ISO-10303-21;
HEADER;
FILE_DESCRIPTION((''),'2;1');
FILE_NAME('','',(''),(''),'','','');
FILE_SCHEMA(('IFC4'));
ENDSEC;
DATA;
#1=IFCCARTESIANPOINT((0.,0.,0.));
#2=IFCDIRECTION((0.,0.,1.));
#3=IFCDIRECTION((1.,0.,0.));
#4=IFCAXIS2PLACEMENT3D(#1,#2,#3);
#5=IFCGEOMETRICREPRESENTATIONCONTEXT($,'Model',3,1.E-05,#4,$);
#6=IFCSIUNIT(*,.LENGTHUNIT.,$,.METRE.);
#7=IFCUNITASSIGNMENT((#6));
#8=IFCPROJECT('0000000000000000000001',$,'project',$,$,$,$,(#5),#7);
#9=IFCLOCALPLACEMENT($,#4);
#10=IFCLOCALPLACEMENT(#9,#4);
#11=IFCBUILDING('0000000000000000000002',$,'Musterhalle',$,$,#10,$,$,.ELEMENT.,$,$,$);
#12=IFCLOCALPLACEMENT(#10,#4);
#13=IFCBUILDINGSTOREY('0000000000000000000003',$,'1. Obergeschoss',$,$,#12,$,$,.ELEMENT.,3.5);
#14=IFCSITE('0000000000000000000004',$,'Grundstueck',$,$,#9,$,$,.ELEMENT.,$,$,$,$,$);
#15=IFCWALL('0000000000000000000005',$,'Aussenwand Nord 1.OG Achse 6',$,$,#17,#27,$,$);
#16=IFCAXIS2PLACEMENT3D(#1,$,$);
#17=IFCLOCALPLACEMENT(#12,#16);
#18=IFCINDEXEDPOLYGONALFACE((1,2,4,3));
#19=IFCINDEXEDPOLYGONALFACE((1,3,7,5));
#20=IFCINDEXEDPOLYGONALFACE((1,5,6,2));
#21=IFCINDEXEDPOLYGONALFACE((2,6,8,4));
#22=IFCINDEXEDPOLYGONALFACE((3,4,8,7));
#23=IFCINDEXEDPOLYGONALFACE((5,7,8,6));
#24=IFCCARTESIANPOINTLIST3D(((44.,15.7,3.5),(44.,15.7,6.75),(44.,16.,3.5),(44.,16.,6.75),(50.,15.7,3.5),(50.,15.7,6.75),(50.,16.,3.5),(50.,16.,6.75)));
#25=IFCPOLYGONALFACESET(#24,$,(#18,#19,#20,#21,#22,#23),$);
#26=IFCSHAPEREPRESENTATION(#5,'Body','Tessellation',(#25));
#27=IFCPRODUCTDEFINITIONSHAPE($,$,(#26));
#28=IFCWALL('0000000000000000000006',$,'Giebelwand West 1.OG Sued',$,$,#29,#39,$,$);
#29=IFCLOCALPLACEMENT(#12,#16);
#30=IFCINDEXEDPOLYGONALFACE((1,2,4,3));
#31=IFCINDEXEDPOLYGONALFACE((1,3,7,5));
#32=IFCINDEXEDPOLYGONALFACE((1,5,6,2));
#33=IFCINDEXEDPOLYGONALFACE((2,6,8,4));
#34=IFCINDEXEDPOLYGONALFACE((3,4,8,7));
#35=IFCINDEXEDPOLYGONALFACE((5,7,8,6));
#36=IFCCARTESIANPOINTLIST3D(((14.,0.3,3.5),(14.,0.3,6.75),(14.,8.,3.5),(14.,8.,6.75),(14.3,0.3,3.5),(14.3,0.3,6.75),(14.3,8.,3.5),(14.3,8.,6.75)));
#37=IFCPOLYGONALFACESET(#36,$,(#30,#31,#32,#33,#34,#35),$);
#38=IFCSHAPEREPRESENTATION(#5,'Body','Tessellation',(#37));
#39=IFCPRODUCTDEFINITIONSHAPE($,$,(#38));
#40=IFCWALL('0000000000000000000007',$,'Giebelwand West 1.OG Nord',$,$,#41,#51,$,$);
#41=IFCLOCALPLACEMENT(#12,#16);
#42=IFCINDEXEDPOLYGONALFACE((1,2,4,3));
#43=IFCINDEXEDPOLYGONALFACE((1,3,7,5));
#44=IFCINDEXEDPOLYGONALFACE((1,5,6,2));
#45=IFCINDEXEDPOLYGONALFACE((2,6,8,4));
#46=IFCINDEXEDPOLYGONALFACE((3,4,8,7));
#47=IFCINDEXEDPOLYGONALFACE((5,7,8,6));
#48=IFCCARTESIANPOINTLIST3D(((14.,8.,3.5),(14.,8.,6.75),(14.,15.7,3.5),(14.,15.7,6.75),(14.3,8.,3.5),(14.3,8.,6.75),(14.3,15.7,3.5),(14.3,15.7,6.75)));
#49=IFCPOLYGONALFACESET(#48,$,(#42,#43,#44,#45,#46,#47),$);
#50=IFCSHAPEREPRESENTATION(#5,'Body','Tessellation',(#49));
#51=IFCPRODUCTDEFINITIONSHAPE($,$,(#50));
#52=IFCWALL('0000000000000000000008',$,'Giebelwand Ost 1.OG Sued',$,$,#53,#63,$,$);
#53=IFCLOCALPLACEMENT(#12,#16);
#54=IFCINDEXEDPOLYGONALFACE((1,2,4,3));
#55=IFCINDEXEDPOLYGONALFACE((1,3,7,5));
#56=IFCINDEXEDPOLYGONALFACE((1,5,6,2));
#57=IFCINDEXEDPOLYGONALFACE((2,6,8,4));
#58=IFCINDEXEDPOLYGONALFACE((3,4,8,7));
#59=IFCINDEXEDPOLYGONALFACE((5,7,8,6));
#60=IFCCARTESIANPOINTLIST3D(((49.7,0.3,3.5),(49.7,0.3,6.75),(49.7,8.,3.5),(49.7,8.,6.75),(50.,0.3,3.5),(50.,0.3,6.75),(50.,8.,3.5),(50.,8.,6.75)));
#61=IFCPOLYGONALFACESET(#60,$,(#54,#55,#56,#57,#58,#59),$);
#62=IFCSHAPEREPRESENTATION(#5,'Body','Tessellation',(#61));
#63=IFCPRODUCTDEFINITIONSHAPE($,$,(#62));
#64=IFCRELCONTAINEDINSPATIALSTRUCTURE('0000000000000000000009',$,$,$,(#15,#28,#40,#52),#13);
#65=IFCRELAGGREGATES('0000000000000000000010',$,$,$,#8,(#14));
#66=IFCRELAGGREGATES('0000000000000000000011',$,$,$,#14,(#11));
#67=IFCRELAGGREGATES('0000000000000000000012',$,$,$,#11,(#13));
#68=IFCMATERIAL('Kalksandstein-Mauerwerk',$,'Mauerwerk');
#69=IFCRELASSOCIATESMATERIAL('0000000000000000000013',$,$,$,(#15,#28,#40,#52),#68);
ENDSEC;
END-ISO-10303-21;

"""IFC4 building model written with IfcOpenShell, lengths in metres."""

from ifc_helpers import new_model, si_unit, frame, origin_with_axes, origin_2d, place, context, project, spatial, rectangle, extrude, material, element, save


model = new_model("IFC4")

# Units and contexts
model_context = context("Model", 3, precision=1e-05, world=origin_with_axes())
ifc_project = project(units=[si_unit("LENGTHUNIT", "METRE")], contexts=[model_context])

# Site, building, storey
site_placement = place(None, origin_with_axes())
site = spatial("IfcSite", under=ifc_project, at=site_placement, Name="Grundstueck", CompositionType="ELEMENT")
building_placement = place(site_placement, origin_with_axes())
building = spatial("IfcBuilding", under=site, at=building_placement, Name="Musterhalle", CompositionType="ELEMENT")
storey_placement = place(building_placement, origin_with_axes())
storey = spatial("IfcBuildingStorey", under=building, at=storey_placement, Name="1. Obergeschoss", CompositionType="ELEMENT", Elevation=3.5)

# Shared definitions
placement = place(storey_placement, origin_with_axes())

# Walls
ifc_material_1 = material(Name="Kalksandstein-Mauerwerk", Category="Mauerwerk")
element("IfcWall", 1, at=placement, inside=storey, material=ifc_material_1, Name="Aussenwand Nord 1.OG Achse 6", context=model_context, shape_type="SweptSolid", body=[
    extrude(rectangle(XDim=6.0, YDim=0.3, at=origin_2d()), frame((47.0, 15.85, 3.5), z_axis=(0.0, 0.0, 1.0), x_axis=(1.0, 0.0, 0.0)), (0.0, 0.0, 1.0), 3.25),
])
element("IfcWall", 2, at=placement, inside=storey, material=ifc_material_1, Name="Giebelwand West 1.OG Sued", context=model_context, shape_type="SweptSolid", body=[
    extrude(rectangle(XDim=0.3, YDim=7.7, at=origin_2d()), frame((14.15, 4.15, 3.5), z_axis=(0.0, 0.0, 1.0), x_axis=(1.0, 0.0, 0.0)), (0.0, 0.0, 1.0), 3.25),
])
element("IfcWall", 3, at=placement, inside=storey, material=ifc_material_1, Name="Giebelwand West 1.OG Nord", context=model_context, shape_type="SweptSolid", body=[
    extrude(rectangle(XDim=0.3, YDim=7.7, at=origin_2d()), frame((14.15, 11.85, 3.5), z_axis=(0.0, 0.0, 1.0), x_axis=(1.0, 0.0, 0.0)), (0.0, 0.0, 1.0), 3.25),
])
element("IfcWall", 4, at=placement, inside=storey, material=ifc_material_1, Name="Giebelwand Ost 1.OG Sued", context=model_context, shape_type="SweptSolid", body=[
    extrude(rectangle(XDim=0.3, YDim=7.7, at=origin_2d()), frame((49.85, 4.15, 3.5), z_axis=(0.0, 0.0, 1.0), x_axis=(1.0, 0.0, 0.0)), (0.0, 0.0, 1.0), 3.25),
])

save(model, "model.ifc")
